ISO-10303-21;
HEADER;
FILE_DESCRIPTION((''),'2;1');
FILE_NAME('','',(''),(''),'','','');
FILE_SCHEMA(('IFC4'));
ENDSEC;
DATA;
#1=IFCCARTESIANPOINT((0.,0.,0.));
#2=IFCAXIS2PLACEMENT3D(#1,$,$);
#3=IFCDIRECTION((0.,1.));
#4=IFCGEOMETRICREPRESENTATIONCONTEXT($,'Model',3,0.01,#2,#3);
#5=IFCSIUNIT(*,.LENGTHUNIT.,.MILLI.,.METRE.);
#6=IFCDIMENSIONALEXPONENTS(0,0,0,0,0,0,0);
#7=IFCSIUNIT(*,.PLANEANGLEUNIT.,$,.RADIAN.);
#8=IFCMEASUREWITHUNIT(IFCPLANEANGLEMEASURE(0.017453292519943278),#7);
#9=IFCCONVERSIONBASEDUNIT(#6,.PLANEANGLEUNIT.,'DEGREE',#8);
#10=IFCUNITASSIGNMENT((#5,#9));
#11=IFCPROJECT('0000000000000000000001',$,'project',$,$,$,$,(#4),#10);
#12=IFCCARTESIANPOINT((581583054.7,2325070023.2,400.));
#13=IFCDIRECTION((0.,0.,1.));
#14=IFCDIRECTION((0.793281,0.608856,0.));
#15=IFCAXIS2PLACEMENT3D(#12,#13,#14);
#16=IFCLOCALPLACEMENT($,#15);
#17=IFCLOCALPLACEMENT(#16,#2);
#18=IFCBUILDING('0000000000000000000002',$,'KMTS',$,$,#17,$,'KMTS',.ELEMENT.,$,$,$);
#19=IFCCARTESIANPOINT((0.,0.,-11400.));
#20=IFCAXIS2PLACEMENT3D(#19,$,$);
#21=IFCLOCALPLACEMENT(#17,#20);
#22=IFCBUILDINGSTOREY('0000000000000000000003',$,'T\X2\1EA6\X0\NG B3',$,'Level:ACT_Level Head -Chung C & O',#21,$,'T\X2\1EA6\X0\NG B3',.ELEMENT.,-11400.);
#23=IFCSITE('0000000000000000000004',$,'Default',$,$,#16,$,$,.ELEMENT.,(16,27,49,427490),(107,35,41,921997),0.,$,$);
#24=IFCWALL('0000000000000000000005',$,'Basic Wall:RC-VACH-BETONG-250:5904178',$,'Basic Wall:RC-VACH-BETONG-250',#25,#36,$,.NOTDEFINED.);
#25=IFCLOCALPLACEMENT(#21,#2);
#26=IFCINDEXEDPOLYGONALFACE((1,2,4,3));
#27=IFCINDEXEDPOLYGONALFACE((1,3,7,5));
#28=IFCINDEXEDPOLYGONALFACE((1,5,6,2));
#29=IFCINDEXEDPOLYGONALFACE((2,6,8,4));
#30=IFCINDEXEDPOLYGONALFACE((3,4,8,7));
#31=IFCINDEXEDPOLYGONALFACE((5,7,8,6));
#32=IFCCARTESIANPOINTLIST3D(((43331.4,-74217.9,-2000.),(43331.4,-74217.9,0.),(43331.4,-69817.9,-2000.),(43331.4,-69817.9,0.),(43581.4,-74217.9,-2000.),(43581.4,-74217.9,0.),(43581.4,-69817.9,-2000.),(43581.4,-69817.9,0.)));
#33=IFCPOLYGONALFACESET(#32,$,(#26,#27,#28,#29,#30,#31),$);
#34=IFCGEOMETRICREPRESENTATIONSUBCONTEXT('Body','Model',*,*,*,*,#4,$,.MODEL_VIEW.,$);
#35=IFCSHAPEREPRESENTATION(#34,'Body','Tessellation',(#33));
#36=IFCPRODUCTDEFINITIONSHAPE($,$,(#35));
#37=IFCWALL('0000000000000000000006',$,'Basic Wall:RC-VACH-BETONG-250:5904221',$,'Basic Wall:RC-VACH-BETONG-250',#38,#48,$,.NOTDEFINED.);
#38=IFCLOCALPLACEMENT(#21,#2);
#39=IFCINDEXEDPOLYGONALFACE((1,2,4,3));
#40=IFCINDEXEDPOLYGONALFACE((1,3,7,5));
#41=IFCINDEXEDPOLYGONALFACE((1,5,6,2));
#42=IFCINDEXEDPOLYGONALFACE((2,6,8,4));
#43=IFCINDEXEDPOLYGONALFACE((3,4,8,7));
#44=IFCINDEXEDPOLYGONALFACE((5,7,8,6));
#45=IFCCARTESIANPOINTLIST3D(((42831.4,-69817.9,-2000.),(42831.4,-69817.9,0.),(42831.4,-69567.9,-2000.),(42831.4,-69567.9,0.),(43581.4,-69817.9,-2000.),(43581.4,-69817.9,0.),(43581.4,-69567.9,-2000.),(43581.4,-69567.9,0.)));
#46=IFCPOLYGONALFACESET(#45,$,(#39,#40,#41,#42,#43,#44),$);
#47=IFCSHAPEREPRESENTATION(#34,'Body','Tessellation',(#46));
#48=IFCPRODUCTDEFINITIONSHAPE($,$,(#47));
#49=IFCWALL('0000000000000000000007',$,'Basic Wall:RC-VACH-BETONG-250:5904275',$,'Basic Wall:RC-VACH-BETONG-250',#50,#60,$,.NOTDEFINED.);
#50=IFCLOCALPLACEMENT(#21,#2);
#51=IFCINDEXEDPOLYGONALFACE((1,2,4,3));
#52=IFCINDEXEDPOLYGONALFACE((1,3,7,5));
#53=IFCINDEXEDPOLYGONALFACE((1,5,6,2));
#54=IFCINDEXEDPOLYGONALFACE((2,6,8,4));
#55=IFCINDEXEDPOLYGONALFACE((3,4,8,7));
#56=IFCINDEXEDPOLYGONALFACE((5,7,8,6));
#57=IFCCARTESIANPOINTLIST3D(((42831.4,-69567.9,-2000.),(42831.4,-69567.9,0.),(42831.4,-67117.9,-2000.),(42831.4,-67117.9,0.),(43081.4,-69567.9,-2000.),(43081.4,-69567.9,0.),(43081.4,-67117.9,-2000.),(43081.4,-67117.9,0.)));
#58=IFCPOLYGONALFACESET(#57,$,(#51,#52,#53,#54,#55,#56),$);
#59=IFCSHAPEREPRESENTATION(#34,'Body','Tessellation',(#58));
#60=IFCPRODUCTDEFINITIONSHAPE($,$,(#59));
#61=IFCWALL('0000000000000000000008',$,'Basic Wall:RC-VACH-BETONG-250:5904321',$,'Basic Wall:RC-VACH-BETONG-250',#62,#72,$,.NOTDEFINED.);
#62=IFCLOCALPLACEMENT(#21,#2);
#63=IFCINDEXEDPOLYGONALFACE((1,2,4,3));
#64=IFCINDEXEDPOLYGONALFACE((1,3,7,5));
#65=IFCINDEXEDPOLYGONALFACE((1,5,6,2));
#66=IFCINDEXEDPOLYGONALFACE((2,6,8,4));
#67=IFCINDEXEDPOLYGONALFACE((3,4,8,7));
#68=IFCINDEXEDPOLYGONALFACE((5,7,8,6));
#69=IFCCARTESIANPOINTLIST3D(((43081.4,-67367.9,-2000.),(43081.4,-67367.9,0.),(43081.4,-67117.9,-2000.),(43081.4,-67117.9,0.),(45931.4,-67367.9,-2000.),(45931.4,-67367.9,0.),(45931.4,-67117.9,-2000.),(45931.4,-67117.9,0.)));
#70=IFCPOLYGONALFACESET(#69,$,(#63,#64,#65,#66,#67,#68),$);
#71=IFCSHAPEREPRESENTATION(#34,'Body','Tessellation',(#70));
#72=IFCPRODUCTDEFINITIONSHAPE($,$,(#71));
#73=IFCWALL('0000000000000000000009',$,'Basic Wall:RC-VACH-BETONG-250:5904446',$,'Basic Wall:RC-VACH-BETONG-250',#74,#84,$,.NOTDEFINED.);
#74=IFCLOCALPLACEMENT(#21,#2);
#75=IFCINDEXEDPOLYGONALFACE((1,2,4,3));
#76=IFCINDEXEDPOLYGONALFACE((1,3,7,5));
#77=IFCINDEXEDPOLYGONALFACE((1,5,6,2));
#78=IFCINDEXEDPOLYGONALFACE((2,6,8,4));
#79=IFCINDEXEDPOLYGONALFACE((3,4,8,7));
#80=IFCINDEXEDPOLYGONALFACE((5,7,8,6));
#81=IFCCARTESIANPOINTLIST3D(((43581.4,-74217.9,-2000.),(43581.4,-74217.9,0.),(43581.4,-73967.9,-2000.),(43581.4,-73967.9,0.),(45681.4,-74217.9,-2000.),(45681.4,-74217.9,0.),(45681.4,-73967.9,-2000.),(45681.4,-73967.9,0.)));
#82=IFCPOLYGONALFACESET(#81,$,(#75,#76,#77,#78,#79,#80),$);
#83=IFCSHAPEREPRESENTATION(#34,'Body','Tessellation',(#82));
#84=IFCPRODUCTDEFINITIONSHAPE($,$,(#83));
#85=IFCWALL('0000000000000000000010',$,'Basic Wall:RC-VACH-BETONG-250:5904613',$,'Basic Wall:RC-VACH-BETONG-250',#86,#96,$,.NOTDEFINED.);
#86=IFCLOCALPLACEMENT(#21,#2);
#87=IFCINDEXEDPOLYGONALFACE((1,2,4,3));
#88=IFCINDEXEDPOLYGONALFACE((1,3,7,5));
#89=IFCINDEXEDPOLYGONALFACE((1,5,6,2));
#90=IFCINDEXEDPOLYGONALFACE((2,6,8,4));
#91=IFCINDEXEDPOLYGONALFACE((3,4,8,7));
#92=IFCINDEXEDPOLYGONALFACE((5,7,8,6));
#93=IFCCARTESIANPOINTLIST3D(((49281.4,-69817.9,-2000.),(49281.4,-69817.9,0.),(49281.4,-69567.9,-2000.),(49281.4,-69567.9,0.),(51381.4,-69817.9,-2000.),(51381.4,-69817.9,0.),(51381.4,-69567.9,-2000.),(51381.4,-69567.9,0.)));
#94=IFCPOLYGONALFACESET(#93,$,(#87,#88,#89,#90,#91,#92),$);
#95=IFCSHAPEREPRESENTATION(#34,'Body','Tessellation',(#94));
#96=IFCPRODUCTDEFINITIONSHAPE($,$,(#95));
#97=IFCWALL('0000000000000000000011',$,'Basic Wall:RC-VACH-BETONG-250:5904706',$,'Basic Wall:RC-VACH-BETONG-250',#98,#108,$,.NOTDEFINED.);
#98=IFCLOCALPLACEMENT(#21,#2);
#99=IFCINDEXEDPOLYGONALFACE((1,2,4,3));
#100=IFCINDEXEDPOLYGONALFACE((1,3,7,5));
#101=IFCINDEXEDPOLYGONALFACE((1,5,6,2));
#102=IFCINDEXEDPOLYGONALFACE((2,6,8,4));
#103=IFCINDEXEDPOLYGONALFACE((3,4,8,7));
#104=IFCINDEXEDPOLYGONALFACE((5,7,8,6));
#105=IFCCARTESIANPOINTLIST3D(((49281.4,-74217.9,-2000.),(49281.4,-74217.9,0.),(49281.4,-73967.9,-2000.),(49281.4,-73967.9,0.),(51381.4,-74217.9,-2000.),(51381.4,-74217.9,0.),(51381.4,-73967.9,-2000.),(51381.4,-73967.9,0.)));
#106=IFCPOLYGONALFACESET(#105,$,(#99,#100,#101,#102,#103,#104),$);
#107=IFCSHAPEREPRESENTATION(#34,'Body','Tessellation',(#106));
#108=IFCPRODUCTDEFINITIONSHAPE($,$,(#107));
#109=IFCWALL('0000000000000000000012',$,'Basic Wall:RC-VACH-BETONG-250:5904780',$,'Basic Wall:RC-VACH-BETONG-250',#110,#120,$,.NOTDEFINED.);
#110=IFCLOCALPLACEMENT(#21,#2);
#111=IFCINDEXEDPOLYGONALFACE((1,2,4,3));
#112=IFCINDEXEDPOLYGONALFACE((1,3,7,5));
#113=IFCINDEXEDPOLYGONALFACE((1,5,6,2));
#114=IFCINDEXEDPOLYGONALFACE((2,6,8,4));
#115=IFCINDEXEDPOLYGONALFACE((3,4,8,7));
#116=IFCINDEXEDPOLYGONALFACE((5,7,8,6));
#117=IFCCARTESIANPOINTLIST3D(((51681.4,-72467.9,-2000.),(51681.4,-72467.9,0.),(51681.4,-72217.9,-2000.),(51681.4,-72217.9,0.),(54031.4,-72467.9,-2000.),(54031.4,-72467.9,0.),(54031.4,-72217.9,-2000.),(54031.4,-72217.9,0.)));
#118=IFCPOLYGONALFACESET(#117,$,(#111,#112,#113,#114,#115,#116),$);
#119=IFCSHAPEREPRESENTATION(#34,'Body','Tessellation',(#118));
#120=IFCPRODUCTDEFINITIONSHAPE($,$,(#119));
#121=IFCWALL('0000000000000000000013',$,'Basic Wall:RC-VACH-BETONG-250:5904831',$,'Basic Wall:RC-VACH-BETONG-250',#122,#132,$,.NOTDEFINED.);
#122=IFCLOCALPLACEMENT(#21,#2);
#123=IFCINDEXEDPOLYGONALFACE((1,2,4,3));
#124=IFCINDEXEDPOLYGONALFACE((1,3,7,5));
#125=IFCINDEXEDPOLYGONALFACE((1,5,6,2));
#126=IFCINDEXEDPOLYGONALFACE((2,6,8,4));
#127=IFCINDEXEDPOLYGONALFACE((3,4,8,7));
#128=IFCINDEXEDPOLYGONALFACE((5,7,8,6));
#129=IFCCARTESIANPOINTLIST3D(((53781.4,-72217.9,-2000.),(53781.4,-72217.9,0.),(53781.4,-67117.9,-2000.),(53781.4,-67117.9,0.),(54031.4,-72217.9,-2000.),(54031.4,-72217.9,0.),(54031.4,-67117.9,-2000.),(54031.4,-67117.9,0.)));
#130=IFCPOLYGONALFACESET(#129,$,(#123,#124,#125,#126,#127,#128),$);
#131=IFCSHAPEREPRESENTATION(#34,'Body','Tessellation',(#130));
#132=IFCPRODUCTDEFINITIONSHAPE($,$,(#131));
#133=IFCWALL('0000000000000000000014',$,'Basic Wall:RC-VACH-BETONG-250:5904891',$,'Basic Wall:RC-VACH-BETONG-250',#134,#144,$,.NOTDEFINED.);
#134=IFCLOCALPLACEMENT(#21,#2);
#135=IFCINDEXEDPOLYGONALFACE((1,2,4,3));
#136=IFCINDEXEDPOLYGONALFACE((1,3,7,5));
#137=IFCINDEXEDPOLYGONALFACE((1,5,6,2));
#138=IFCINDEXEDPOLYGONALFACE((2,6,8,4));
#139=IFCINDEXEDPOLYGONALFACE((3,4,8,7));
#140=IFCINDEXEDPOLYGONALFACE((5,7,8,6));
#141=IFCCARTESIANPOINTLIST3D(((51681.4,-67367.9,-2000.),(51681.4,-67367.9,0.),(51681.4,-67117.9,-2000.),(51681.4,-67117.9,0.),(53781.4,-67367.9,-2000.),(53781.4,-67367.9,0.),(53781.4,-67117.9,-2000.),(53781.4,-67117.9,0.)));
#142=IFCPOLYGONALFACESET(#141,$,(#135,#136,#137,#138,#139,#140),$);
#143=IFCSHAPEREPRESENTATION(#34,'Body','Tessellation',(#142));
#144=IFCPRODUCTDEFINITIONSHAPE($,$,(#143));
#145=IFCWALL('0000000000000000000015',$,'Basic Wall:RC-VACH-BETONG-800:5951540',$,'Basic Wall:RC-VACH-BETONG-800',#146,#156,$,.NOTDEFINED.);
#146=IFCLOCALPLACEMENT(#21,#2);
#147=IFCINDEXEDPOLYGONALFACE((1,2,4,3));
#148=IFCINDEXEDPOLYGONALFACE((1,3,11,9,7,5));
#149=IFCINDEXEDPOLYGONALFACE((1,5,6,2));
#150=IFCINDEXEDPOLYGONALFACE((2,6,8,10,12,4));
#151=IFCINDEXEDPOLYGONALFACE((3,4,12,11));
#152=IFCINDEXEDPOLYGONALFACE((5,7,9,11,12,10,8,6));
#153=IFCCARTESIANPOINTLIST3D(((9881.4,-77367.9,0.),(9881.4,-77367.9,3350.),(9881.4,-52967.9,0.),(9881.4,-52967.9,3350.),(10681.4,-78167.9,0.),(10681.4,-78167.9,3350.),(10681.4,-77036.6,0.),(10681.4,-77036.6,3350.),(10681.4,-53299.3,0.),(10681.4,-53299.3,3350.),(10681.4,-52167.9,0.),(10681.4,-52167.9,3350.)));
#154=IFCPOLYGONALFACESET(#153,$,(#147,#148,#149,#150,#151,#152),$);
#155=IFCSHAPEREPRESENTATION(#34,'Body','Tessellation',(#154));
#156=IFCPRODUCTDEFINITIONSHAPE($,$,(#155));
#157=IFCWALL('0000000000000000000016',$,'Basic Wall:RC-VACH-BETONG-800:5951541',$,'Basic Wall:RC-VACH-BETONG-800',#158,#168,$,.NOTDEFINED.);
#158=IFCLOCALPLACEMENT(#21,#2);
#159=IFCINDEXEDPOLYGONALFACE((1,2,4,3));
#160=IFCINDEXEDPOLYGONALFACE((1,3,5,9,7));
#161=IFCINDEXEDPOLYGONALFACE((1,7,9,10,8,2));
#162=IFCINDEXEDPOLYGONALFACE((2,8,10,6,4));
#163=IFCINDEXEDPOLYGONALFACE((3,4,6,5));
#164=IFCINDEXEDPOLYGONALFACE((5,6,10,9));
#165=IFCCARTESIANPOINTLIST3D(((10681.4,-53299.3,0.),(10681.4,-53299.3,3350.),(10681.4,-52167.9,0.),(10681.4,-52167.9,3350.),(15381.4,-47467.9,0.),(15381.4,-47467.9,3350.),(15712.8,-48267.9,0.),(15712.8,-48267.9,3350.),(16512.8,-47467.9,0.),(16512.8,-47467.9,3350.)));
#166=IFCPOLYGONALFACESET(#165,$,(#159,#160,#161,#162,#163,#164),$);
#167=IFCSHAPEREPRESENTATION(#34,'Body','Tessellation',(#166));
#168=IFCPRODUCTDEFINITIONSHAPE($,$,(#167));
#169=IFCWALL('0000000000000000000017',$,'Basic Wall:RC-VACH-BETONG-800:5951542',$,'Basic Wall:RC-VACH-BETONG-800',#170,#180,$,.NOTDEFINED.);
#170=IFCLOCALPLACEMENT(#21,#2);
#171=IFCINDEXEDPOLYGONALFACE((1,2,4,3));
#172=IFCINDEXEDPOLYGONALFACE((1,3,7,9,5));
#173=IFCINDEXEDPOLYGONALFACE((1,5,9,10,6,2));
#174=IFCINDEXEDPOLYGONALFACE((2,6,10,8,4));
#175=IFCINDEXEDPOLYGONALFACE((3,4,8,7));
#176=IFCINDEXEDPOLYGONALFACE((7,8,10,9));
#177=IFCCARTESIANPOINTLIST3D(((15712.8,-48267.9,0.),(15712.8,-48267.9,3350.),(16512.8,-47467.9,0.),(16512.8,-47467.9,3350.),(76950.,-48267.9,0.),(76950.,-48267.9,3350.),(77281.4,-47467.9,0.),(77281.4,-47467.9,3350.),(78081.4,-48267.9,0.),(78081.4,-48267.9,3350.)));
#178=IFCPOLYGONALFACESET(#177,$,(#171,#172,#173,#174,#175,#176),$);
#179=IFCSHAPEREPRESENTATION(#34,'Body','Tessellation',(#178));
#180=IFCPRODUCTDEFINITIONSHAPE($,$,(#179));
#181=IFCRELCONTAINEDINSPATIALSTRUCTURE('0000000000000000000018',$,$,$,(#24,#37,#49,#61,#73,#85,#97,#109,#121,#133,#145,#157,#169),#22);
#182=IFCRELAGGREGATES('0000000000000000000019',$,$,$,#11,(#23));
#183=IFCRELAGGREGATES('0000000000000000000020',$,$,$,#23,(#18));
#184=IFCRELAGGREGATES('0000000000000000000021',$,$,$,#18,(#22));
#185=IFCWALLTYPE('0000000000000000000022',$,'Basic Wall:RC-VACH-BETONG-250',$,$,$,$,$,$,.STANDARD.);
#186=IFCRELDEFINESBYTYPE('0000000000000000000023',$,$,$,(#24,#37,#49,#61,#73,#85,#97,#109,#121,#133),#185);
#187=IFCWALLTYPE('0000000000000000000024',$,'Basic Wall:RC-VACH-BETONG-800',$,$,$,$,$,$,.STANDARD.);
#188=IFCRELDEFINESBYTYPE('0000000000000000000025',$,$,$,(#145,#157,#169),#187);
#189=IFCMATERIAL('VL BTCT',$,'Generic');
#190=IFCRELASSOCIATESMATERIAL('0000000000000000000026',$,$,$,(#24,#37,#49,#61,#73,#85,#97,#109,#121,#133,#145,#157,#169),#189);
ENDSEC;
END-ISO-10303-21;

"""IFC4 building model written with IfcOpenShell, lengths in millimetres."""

from ifc_helpers import new_model, entity, si_unit, converted_unit, direction, frame, origin, place, context, subcontext, project, spatial, indexed_curve, outline, extrude, material, type_object, element, save


model = new_model("IFC4")

# Units and contexts
model_context = context("Model", 3, precision=0.01, world=origin(), true_north=direction((0.0, 1.0)))
body_context = subcontext(model_context, "Body", "Model", "MODEL_VIEW")
ifc_project = project(units=[si_unit("LENGTHUNIT", "METRE", prefix="MILLI"), converted_unit("PLANEANGLEUNIT", "DEGREE", entity("IfcPlaneAngleMeasure", 0.017453292519943278), si_unit("PLANEANGLEUNIT", "RADIAN"), dimensions=[0, 0, 0, 0, 0, 0, 0])], contexts=[model_context])

# Site, building, storey
site_placement = place(None, frame((581583054.7, 2325070023.2, 400.0), z_axis=(0.0, 0.0, 1.0), x_axis=(0.793281, 0.608856, 0.0)))
site = spatial("IfcSite", under=ifc_project, at=site_placement, Name="Default", CompositionType="ELEMENT", RefLatitude=(16, 27, 49, 427490), RefLongitude=(107, 35, 41, 921997), RefElevation=0.0)
building_placement = place(site_placement, origin())
building = spatial("IfcBuilding", under=site, at=building_placement, Name="KMTS", LongName="KMTS", CompositionType="ELEMENT")
storey_placement = place(building_placement, frame((0.0, 0.0, -11400.0)))
storey = spatial("IfcBuildingStorey", under=building, at=storey_placement, Name="TẦNG B3", ObjectType="Level:ACT_Level Head -Chung C & O", LongName="TẦNG B3", CompositionType="ELEMENT", Elevation=-11400.0)

# Shared definitions
ifc_material = material(Name="VL BTCT", Category="Generic")

# Walls
wall_type_1 = type_object("IfcWallType", Name="Basic Wall:RC-VACH-BETONG-250", PredefinedType="STANDARD")
wall_1_placement = place(storey_placement, frame((43456.4, -74217.9, -2000.0), z_axis=(0.0, 0.0, 1.0), x_axis=(0.0, 1.0, 0.0)))
element("IfcWall", 1, at=wall_1_placement, inside=storey, type_object=wall_type_1, material=ifc_material, Name="Basic Wall:RC-VACH-BETONG-250:5904178", ObjectType="Basic Wall:RC-VACH-BETONG-250", PredefinedType="NOTDEFINED", context=body_context, shape_type="SweptSolid", body=[
    extrude(outline(indexed_curve([(4400.0, 125.0), (0.0, 125.0), (0.0, -125.0), (4400.0, -125.0), (4400.0, 125.0)], self_intersect=False)), origin(), (0.0, 0.0, 1.0), 2000.0),
])
wall_2_placement = place(storey_placement, frame((43581.4, -69692.9, -2000.0), z_axis=(0.0, 0.0, 1.0), x_axis=(-1.0, 0.0, 0.0)))
element("IfcWall", 2, at=wall_2_placement, inside=storey, type_object=wall_type_1, material=ifc_material, Name="Basic Wall:RC-VACH-BETONG-250:5904221", ObjectType="Basic Wall:RC-VACH-BETONG-250", PredefinedType="NOTDEFINED", context=body_context, shape_type="SweptSolid", body=[
    extrude(outline(indexed_curve([(750.0, 125.0), (0.0, 125.0), (0.0, -125.0), (750.0, -125.0), (750.0, 125.0)], self_intersect=False)), origin(), (0.0, 0.0, 1.0), 2000.0),
])
wall_3_placement = place(storey_placement, frame((42956.4, -69567.9, -2000.0), z_axis=(0.0, 0.0, 1.0), x_axis=(0.0, 1.0, 0.0)))
element("IfcWall", 3, at=wall_3_placement, inside=storey, type_object=wall_type_1, material=ifc_material, Name="Basic Wall:RC-VACH-BETONG-250:5904275", ObjectType="Basic Wall:RC-VACH-BETONG-250", PredefinedType="NOTDEFINED", context=body_context, shape_type="SweptSolid", body=[
    extrude(outline(indexed_curve([(2450.0, 125.0), (0.0, 125.0), (0.0, -125.0), (2450.0, -125.0), (2450.0, 125.0)], self_intersect=False)), origin(), (0.0, 0.0, 1.0), 2000.0),
])
wall_4_placement = place(storey_placement, frame((43081.4, -67242.9, -2000.0)))
element("IfcWall", 4, at=wall_4_placement, inside=storey, type_object=wall_type_1, material=ifc_material, Name="Basic Wall:RC-VACH-BETONG-250:5904321", ObjectType="Basic Wall:RC-VACH-BETONG-250", PredefinedType="NOTDEFINED", context=body_context, shape_type="SweptSolid", body=[
    extrude(outline(indexed_curve([(2850.0, 125.0), (0.0, 125.0), (0.0, -125.0), (2850.0, -125.0), (2850.0, 125.0)], self_intersect=False)), origin(), (0.0, 0.0, 1.0), 2000.0),
])
wall_5_placement = place(storey_placement, frame((45681.4, -74092.9, -2000.0), z_axis=(0.0, 0.0, 1.0), x_axis=(-1.0, 0.0, 0.0)))
element("IfcWall", 5, at=wall_5_placement, inside=storey, type_object=wall_type_1, material=ifc_material, Name="Basic Wall:RC-VACH-BETONG-250:5904446", ObjectType="Basic Wall:RC-VACH-BETONG-250", PredefinedType="NOTDEFINED", context=body_context, shape_type="SweptSolid", body=[
    extrude(outline(indexed_curve([(2100.0, 125.0), (0.0, 125.0), (0.0, -125.0), (2100.0, -125.0), (2100.0, 125.0)], self_intersect=False)), origin(), (0.0, 0.0, 1.0), 2000.0),
])
wall_6_placement = place(storey_placement, frame((49281.4, -69692.9, -2000.0)))
element("IfcWall", 6, at=wall_6_placement, inside=storey, type_object=wall_type_1, material=ifc_material, Name="Basic Wall:RC-VACH-BETONG-250:5904613", ObjectType="Basic Wall:RC-VACH-BETONG-250", PredefinedType="NOTDEFINED", context=body_context, shape_type="SweptSolid", body=[
    extrude(outline(indexed_curve([(2100.0, 125.0), (0.0, 125.0), (0.0, -125.0), (2100.0, -125.0), (2100.0, 125.0)], self_intersect=False)), origin(), (0.0, 0.0, 1.0), 2000.0),
])
wall_7_placement = place(storey_placement, frame((51381.4, -74092.9, -2000.0), z_axis=(0.0, 0.0, 1.0), x_axis=(-1.0, 0.0, 0.0)))
element("IfcWall", 7, at=wall_7_placement, inside=storey, type_object=wall_type_1, material=ifc_material, Name="Basic Wall:RC-VACH-BETONG-250:5904706", ObjectType="Basic Wall:RC-VACH-BETONG-250", PredefinedType="NOTDEFINED", context=body_context, shape_type="SweptSolid", body=[
    extrude(outline(indexed_curve([(2100.0, 125.0), (0.0, 125.0), (0.0, -125.0), (2100.0, -125.0), (2100.0, 125.0)], self_intersect=False)), origin(), (0.0, 0.0, 1.0), 2000.0),
])
wall_8_placement = place(storey_placement, frame((51681.4, -72342.9, -2000.0)))
element("IfcWall", 8, at=wall_8_placement, inside=storey, type_object=wall_type_1, material=ifc_material, Name="Basic Wall:RC-VACH-BETONG-250:5904780", ObjectType="Basic Wall:RC-VACH-BETONG-250", PredefinedType="NOTDEFINED", context=body_context, shape_type="SweptSolid", body=[
    extrude(outline(indexed_curve([(2350.0, 125.0), (0.0, 125.0), (0.0, -125.0), (2350.0, -125.0), (2350.0, 125.0)], self_intersect=False)), origin(), (0.0, 0.0, 1.0), 2000.0),
])
wall_9_placement = place(storey_placement, frame((53906.4, -72217.9, -2000.0), z_axis=(0.0, 0.0, 1.0), x_axis=(0.0, 1.0, 0.0)))
element("IfcWall", 9, at=wall_9_placement, inside=storey, type_object=wall_type_1, material=ifc_material, Name="Basic Wall:RC-VACH-BETONG-250:5904831", ObjectType="Basic Wall:RC-VACH-BETONG-250", PredefinedType="NOTDEFINED", context=body_context, shape_type="SweptSolid", body=[
    extrude(outline(indexed_curve([(5100.0, 125.0), (0.0, 125.0), (0.0, -125.0), (5100.0, -125.0), (5100.0, 125.0)], self_intersect=False)), origin(), (0.0, 0.0, 1.0), 2000.0),
])
wall_10_placement = place(storey_placement, frame((53781.4, -67242.9, -2000.0), z_axis=(0.0, 0.0, 1.0), x_axis=(-1.0, 0.0, 0.0)))
element("IfcWall", 10, at=wall_10_placement, inside=storey, type_object=wall_type_1, material=ifc_material, Name="Basic Wall:RC-VACH-BETONG-250:5904891", ObjectType="Basic Wall:RC-VACH-BETONG-250", PredefinedType="NOTDEFINED", context=body_context, shape_type="SweptSolid", body=[
    extrude(outline(indexed_curve([(2100.0, 125.0), (0.0, 125.0), (0.0, -125.0), (2100.0, -125.0), (2100.0, 125.0)], self_intersect=False)), origin(), (0.0, 0.0, 1.0), 2000.0),
])
wall_type_2 = type_object("IfcWallType", Name="Basic Wall:RC-VACH-BETONG-800", PredefinedType="STANDARD")
wall_11_placement = place(storey_placement, frame((10281.4, -78167.9, 0.0), z_axis=(0.0, 0.0, 1.0), x_axis=(0.0, 1.0, 0.0)))
element("IfcWall", 11, at=wall_11_placement, inside=storey, type_object=wall_type_2, material=ifc_material, Name="Basic Wall:RC-VACH-BETONG-800:5951540", ObjectType="Basic Wall:RC-VACH-BETONG-800", PredefinedType="NOTDEFINED", context=body_context, shape_type="SweptSolid", body=[
    extrude(outline(indexed_curve([(26000.0, -400.0), (25200.0, 400.0), (800.0, 400.0), (0.0, -400.0), (1131.4, -400.0), (24868.6, -400.0), (26000.0, -400.0)], self_intersect=False)), origin(), (0.0, 0.0, 1.0), 3350.0),
])
wall_12_placement = place(storey_placement, frame((10398.5, -53016.5, 0.0), z_axis=(0.0, 0.0, 1.0), x_axis=(0.707107, 0.707107, 0.0)))
element("IfcWall", 12, at=wall_12_placement, inside=storey, type_object=wall_type_2, material=ifc_material, Name="Basic Wall:RC-VACH-BETONG-800:5951541", ObjectType="Basic Wall:RC-VACH-BETONG-800", PredefinedType="NOTDEFINED", context=body_context, shape_type="SweptSolid", body=[
    extrude(outline(indexed_curve([(8246.8, -400.0), (7446.8, 400.0), (800.0, 400.0), (0.0, -400.0), (7115.4, -400.0), (8246.8, -400.0)], self_intersect=False)), origin(), (0.0, 0.0, 1.0), 3350.0),
])
wall_13_placement = place(storey_placement, frame((15712.8, -47867.9, 0.0)))
element("IfcWall", 13, at=wall_13_placement, inside=storey, type_object=wall_type_2, material=ifc_material, Name="Basic Wall:RC-VACH-BETONG-800:5951542", ObjectType="Basic Wall:RC-VACH-BETONG-800", PredefinedType="NOTDEFINED", context=body_context, shape_type="SweptSolid", body=[
    extrude(outline(indexed_curve([(62368.6, -400.0), (61568.6, 400.0), (800.0, 400.0), (0.0, -400.0), (61237.3, -400.0), (62368.6, -400.0)], self_intersect=False)), origin(), (0.0, 0.0, 1.0), 3350.0),
])

save(model, "model.ifc")
